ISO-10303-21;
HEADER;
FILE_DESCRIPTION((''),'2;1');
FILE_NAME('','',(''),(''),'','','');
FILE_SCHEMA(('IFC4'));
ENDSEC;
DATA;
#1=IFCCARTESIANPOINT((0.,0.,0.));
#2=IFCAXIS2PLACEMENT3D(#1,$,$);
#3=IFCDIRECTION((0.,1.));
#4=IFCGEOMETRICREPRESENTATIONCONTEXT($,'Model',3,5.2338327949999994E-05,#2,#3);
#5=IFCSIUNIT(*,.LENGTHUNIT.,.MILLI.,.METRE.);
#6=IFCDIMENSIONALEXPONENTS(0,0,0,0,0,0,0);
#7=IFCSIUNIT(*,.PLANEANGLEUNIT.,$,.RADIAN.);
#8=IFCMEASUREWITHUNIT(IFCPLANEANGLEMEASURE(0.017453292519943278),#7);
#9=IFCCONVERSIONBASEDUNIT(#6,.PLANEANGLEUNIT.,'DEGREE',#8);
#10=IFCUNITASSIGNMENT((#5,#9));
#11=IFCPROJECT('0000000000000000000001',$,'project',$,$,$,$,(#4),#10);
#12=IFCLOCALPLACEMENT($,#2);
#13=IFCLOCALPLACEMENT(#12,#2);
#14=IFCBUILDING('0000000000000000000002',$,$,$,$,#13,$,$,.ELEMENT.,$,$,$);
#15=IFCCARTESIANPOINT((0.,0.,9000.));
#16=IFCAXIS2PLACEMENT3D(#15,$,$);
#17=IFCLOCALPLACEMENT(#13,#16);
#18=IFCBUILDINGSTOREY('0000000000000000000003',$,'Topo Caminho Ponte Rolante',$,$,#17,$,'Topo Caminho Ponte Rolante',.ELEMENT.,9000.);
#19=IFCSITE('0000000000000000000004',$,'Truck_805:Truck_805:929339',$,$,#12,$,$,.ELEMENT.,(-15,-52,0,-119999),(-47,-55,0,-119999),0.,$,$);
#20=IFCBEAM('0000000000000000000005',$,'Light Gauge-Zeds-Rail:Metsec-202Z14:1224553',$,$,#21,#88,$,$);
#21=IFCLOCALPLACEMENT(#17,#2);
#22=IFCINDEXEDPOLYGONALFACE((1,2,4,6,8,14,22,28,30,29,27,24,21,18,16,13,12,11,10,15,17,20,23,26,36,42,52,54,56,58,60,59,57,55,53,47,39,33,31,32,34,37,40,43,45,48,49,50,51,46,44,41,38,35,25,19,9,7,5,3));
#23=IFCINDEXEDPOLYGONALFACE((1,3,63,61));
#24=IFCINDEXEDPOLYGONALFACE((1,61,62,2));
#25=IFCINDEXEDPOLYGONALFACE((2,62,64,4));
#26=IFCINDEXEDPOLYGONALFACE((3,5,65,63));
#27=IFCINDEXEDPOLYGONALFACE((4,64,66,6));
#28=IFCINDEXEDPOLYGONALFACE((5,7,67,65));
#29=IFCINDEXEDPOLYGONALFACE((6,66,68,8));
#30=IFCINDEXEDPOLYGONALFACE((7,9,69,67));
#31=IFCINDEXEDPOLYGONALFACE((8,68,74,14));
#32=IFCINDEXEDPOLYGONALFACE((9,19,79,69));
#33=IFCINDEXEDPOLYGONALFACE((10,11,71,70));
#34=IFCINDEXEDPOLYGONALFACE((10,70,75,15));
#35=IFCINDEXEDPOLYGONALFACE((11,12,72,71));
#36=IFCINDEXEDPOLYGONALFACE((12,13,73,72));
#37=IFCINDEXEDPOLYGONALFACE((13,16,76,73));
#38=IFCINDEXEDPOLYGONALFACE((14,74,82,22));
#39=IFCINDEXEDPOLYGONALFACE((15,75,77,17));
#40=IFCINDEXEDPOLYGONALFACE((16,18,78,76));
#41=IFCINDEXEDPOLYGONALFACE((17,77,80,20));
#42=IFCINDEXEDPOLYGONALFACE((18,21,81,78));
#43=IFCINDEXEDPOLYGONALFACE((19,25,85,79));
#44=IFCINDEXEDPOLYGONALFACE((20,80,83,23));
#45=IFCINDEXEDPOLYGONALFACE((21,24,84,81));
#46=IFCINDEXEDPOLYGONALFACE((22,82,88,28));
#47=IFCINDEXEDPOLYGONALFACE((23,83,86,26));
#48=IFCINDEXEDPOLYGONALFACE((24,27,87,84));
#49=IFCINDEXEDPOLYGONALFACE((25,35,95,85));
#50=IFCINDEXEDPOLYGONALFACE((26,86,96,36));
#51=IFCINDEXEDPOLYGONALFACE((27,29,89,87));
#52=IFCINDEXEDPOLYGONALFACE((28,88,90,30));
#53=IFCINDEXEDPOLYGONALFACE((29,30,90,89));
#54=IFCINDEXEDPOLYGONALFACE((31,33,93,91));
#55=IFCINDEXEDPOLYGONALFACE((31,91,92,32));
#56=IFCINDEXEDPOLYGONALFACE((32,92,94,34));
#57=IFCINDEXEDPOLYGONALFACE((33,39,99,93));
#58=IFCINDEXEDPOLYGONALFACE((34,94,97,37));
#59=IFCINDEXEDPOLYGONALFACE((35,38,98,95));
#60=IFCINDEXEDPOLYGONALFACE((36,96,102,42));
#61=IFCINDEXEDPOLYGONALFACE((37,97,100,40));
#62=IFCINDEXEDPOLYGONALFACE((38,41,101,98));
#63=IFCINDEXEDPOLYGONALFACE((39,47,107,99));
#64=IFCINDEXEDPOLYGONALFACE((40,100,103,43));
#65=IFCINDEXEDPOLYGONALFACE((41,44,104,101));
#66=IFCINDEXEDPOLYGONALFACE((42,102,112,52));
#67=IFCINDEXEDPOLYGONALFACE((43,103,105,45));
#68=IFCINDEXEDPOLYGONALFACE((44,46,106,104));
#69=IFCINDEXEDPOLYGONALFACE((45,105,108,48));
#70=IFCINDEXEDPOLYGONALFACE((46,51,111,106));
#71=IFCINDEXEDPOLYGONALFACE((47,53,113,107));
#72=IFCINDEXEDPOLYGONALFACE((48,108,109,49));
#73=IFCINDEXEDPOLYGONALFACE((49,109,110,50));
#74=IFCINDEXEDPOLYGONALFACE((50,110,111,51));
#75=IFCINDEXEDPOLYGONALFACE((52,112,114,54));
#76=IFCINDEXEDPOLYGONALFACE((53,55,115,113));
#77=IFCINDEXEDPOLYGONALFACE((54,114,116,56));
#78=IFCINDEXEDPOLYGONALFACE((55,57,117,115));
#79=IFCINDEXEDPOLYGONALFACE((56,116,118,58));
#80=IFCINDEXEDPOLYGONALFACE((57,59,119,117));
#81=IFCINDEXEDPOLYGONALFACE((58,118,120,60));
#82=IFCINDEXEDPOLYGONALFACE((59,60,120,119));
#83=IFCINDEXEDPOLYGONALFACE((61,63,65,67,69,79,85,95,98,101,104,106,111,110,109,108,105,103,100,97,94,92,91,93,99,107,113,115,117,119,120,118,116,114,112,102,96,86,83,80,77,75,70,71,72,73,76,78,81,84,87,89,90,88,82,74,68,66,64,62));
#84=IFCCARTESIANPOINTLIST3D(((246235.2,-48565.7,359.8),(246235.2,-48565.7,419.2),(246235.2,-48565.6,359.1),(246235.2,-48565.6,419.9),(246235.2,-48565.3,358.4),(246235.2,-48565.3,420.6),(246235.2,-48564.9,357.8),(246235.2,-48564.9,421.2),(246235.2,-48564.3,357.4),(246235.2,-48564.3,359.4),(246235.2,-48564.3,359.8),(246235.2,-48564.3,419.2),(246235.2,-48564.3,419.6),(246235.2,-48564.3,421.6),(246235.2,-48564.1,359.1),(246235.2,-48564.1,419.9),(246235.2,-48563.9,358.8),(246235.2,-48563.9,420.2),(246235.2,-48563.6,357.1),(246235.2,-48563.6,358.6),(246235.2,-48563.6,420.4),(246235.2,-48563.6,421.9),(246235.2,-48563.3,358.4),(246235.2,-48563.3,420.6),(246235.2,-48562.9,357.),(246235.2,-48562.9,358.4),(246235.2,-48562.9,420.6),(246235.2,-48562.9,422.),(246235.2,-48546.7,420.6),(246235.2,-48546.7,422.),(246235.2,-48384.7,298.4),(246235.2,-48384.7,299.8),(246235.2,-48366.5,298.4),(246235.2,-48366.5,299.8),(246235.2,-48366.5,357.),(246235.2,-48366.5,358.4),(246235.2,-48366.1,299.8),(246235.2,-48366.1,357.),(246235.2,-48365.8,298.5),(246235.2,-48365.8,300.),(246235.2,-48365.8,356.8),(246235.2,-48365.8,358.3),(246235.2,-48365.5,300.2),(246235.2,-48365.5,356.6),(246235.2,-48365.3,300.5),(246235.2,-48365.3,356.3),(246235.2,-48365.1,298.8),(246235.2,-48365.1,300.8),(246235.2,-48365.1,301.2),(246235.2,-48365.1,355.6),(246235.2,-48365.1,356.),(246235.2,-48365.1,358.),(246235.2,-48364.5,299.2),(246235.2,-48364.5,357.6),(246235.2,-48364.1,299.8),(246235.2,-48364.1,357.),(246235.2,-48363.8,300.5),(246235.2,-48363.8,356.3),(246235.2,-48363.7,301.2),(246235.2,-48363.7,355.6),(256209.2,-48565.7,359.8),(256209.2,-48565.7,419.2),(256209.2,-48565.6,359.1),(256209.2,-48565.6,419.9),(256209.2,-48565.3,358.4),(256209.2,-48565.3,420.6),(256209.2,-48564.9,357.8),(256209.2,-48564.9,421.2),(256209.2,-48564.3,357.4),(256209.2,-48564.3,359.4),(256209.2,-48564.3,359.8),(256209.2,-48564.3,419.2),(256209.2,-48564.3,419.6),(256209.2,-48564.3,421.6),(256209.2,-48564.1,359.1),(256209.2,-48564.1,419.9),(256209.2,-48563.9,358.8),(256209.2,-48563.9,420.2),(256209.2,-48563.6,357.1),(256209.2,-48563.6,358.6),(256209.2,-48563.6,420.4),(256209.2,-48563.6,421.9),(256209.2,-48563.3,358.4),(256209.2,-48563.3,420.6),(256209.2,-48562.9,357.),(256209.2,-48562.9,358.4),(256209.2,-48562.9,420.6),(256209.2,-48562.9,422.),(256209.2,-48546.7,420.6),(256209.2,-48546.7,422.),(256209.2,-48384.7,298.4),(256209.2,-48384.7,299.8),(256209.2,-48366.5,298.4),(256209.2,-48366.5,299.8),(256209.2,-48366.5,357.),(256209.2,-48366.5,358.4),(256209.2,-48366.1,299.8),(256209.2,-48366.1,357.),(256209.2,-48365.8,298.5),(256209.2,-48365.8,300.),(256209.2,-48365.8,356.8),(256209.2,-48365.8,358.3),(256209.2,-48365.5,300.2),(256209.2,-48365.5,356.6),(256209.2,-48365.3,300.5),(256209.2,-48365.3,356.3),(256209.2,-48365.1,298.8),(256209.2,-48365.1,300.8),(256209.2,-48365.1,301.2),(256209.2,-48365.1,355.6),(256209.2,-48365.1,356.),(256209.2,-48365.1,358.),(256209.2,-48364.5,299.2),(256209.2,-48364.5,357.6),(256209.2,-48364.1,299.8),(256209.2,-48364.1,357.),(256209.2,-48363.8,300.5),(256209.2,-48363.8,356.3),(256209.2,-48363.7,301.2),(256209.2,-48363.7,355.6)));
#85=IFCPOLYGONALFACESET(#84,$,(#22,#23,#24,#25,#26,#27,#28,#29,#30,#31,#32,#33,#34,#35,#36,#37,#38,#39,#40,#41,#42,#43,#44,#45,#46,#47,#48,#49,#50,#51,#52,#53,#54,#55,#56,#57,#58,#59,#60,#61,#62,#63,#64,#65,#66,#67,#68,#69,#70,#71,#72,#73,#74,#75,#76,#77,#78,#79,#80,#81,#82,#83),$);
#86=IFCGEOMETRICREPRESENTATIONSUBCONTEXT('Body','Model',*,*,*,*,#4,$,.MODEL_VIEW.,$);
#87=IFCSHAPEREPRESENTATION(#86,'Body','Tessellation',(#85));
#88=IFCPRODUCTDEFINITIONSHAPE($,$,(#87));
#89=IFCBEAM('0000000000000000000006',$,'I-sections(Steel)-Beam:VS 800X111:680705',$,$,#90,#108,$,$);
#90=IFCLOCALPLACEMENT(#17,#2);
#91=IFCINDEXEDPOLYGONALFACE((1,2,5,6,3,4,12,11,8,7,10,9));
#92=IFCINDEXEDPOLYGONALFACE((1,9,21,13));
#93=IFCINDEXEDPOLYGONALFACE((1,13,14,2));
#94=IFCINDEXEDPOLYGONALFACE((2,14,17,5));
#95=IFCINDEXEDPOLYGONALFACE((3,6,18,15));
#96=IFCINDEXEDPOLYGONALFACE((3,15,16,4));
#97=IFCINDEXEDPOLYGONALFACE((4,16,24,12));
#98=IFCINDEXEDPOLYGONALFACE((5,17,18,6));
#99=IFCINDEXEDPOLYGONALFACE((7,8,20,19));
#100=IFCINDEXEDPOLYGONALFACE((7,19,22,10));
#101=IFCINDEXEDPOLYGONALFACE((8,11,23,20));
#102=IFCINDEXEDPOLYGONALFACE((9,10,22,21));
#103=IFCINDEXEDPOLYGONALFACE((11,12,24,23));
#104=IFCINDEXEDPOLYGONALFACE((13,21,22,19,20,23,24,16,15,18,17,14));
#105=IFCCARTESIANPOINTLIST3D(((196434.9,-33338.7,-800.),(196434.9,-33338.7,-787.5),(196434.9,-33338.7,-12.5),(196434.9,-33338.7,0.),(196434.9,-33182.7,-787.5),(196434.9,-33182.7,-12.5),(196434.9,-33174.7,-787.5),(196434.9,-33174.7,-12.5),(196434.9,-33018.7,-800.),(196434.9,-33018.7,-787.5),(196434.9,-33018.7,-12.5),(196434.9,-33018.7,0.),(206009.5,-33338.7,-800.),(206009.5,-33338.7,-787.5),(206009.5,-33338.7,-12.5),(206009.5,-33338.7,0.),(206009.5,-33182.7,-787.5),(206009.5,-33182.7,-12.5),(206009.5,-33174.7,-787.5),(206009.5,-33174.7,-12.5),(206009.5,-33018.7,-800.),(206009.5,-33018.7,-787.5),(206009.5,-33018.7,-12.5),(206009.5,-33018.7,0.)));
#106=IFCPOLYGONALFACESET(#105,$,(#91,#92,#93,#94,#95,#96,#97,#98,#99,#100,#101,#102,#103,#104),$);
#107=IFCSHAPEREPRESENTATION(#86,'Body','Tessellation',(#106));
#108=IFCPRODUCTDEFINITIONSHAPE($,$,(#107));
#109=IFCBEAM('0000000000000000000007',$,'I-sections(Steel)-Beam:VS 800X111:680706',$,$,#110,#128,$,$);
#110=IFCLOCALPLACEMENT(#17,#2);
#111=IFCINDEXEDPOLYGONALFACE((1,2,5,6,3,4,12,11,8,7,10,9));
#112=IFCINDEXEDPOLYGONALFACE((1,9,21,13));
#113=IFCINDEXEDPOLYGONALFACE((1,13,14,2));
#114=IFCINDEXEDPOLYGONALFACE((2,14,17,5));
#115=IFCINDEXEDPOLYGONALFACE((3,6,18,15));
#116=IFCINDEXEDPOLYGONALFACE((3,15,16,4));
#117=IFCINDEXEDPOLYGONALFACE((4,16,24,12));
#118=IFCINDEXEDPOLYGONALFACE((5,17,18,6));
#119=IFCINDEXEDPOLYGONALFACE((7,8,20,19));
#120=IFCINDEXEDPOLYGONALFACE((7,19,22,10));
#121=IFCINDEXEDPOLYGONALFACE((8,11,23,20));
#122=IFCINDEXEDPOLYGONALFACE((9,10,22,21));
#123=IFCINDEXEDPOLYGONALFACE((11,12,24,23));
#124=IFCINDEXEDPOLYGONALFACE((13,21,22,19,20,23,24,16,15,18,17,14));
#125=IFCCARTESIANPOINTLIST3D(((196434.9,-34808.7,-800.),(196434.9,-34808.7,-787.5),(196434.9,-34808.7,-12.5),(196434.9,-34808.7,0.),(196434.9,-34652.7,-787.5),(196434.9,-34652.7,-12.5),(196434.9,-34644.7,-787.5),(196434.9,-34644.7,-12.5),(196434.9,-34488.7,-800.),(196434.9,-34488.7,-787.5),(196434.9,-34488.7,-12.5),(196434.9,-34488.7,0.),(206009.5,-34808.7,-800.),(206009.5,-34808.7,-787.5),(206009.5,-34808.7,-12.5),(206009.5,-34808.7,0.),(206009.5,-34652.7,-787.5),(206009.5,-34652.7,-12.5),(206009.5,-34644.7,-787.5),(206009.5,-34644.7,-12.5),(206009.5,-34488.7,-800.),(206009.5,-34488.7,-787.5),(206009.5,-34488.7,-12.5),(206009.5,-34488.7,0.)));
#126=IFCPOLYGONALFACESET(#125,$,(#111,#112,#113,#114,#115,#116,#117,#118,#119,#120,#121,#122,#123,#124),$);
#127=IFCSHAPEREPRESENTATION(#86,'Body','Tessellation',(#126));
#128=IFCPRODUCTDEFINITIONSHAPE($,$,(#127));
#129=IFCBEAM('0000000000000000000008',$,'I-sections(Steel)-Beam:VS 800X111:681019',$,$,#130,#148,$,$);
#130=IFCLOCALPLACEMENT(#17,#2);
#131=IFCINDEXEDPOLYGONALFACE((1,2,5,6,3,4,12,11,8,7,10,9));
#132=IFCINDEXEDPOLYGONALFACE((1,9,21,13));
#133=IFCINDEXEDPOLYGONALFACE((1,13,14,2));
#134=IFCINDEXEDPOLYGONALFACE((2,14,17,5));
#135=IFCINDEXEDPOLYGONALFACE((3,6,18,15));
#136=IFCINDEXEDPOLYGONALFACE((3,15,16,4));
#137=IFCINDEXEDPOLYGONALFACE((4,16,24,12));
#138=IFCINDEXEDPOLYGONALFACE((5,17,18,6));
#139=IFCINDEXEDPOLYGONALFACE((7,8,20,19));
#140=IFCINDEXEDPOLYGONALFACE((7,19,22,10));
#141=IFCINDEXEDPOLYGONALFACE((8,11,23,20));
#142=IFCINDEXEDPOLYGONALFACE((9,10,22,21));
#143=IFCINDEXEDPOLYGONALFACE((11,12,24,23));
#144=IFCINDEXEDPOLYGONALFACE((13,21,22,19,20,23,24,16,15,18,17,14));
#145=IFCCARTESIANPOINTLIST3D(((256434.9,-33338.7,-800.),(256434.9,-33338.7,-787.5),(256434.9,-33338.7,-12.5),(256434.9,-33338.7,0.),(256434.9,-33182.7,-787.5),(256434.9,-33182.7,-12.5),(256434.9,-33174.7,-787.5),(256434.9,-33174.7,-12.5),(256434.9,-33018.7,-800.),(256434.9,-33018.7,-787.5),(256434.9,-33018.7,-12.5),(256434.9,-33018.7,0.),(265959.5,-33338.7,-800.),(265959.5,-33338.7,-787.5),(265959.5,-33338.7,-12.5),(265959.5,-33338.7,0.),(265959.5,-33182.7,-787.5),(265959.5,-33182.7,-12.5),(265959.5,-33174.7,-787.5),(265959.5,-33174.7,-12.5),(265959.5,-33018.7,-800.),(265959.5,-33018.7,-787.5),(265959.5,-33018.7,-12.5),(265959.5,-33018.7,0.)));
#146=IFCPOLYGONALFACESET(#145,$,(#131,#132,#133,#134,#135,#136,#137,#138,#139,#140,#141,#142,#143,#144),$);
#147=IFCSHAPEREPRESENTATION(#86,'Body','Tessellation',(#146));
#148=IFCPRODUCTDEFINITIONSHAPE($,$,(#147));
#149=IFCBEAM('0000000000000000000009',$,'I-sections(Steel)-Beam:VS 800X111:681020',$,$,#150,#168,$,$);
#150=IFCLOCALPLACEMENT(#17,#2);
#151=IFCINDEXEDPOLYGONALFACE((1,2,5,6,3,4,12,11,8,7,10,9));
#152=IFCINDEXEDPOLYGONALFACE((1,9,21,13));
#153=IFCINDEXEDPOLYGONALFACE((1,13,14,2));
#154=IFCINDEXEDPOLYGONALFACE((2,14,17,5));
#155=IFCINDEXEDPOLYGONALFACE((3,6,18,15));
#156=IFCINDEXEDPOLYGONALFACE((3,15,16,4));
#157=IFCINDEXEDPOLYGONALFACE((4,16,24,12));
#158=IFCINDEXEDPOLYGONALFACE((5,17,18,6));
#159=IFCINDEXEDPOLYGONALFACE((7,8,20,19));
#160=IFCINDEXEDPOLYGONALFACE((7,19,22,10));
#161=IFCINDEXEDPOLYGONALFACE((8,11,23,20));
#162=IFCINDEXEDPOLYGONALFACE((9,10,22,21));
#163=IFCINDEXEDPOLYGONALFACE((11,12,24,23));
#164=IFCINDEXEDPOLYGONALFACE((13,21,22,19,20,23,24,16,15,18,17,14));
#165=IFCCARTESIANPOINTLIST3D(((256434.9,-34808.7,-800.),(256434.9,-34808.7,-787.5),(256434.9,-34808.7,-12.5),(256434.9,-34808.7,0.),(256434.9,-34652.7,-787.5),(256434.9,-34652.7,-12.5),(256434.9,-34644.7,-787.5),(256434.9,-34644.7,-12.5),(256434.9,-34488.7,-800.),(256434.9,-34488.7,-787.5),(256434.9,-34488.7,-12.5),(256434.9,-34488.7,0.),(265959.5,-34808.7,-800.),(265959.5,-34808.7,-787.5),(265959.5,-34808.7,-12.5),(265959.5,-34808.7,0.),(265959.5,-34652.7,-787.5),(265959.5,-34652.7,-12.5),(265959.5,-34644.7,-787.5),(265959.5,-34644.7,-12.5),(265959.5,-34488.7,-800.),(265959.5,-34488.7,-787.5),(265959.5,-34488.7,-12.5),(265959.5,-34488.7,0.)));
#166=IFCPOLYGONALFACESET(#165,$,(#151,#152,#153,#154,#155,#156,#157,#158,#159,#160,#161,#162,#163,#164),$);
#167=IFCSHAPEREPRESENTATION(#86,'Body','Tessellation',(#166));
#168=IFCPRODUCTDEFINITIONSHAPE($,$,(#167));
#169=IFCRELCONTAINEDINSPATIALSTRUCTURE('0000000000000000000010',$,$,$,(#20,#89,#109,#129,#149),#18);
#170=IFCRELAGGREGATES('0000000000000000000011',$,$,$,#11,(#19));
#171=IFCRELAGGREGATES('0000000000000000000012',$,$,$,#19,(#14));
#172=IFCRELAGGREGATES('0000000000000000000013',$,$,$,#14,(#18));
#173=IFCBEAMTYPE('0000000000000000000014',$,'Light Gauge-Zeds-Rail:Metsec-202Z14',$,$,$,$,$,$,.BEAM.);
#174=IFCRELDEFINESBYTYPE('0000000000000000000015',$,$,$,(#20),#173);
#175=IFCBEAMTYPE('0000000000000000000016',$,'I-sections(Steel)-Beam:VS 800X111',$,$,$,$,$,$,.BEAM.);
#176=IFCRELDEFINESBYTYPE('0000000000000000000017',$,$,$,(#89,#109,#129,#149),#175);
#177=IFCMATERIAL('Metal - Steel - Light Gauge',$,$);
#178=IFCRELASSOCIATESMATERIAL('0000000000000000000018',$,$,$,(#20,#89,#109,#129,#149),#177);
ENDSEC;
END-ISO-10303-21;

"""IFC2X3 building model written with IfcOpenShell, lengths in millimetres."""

from ifc_helpers import new_model, entity, si_unit, converted_unit, direction, frame, frame_2d, origin, place, context, subcontext, project, spatial, polyline, circle_curve, parameter, trimmed, segment, composite_curve, i_section, outline, extrude, material, type_object, element, save


model = new_model("IFC2X3")

# Units and contexts
model_context = context("Model", 3, precision=5.2338327949999994e-05, world=origin(), true_north=direction((0.0, 1.0)))
body_context = subcontext(model_context, "Body", "Model", "MODEL_VIEW")
ifc_project = project(units=[si_unit("LENGTHUNIT", "METRE", prefix="MILLI"), converted_unit("PLANEANGLEUNIT", "DEGREE", entity("IfcPlaneAngleMeasure", 0.017453292519943278), si_unit("PLANEANGLEUNIT", "RADIAN"), dimensions=[0, 0, 0, 0, 0, 0, 0])], contexts=[model_context])

# Site, building, storey
site_placement = place(None, origin())
site = spatial("IfcSite", under=ifc_project, at=site_placement, Name="Truck_805:Truck_805:929339", CompositionType="ELEMENT", RefLatitude=(-15, -52, 0, -119999), RefLongitude=(-47, -55, 0, -119999), RefElevation=0.0)
building_placement = place(site_placement, origin())
building = spatial("IfcBuilding", under=site, at=building_placement, CompositionType="ELEMENT")
storey_placement = place(building_placement, frame((0.0, 0.0, 9000.0)))
storey = spatial("IfcBuildingStorey", under=building, at=storey_placement, Name="Topo Caminho Ponte Rolante", LongName="Topo Caminho Ponte Rolante", CompositionType="ELEMENT", Elevation=9000.0)

# Beams
ifc_material = material(Name="Metal - Steel - Light Gauge")
beam_type_1 = type_object("IfcBeamType", Name="Light Gauge-Zeds-Rail:Metsec-202Z14", PredefinedType="BEAM")
beam_1_placement = place(storey_placement, frame((246222.2, -48465.6, 422.0)))
element("IfcBeam", 1, at=beam_1_placement, inside=storey, type_object=beam_type_1, material=ifc_material, Name="Light Gauge-Zeds-Rail:Metsec-202Z14:1224553", context=body_context, shape_type="SweptSolid", body=[
    extrude(outline(composite_curve([segment(polyline([(-60.0, -100.8), (-0.6, -100.8)]), True, "CONTINUOUS"), segment(trimmed(circle_curve(frame_2d((-0.6, -98.0), x_axis=(0.0, -1.0)), 2.8), [parameter(0.0)], [parameter(90.0)], True, "PARAMETER"), True, "CONTINUOUS"), segment(polyline([(2.2, -98.0), (2.2, 98.4)]), True, "CONTINUOUS"), segment(trimmed(circle_curve(frame_2d((3.6, 98.4), x_axis=(-1.0, 0.0)), 1.4), [parameter(270.0)], [parameter(0.0)], True, "PARAMETER"), False, "CONTINUOUS"), segment(polyline([(3.6, 99.8), (58.0, 99.8)]), True, "CONTINUOUS"), segment(trimmed(circle_curve(frame_2d((58.0, 98.4), x_axis=(0.0, 1.0)), 1.4), [parameter(270.0)], [parameter(0.0)], True, "PARAMETER"), False, "CONTINUOUS"), segment(polyline([(59.4, 98.4), (59.4, 80.2)]), True, "CONTINUOUS"), segment(polyline([(59.4, 80.2), (60.8, 80.2)]), True, "CONTINUOUS"), segment(polyline([(60.8, 80.2), (60.8, 98.4)]), True, "CONTINUOUS"), segment(trimmed(circle_curve(frame_2d((58.0, 98.4), x_axis=(1.0, 0.0)), 2.8), [parameter(0.0)], [parameter(90.0)], True, "PARAMETER"), True, "CONTINUOUS"), segment(polyline([(58.0, 101.2), (3.6, 101.2)]), True, "CONTINUOUS"), segment(trimmed(circle_curve(frame_2d((3.6, 98.4), x_axis=(0.0, 1.0)), 2.8), [parameter(0.0)], [parameter(90.0)], True, "PARAMETER"), True, "CONTINUOUS"), segment(polyline([(0.8, 98.4), (0.8, -98.0)]), True, "CONTINUOUS"), segment(trimmed(circle_curve(frame_2d((-0.6, -98.0), x_axis=(1.0, 0.0)), 1.4), [parameter(270.0)], [parameter(0.0)], True, "PARAMETER"), False, "CONTINUOUS"), segment(polyline([(-0.6, -99.4), (-60.0, -99.4)]), True, "CONTINUOUS"), segment(trimmed(circle_curve(frame_2d((-60.0, -98.0), x_axis=(0.0, -1.0)), 1.4), [parameter(270.0)], [parameter(0.0)], True, "PARAMETER"), False, "CONTINUOUS"), segment(polyline([(-61.4, -98.0), (-61.4, -81.8)]), True, "CONTINUOUS"), segment(polyline([(-61.4, -81.8), (-62.8, -81.8)]), True, "CONTINUOUS"), segment(polyline([(-62.8, -81.8), (-62.8, -98.0)]), True, "CONTINUOUS"), segment(trimmed(circle_curve(frame_2d((-60.0, -98.0), x_axis=(-1.0, 0.0)), 2.8), [parameter(0.0)], [parameter(90.0)], True, "PARAMETER"), True, "CONTINUOUS")], self_intersect=False)), frame((13.0, 0.7, -62.8), z_axis=(1.0, 0.0, 0.0), x_axis=(0.0, 0.0, -1.0)), (0.0, 0.0, 1.0), 9974.0),
])
beam_type_2 = type_object("IfcBeamType", Name="I-sections(Steel)-Beam:VS 800X111", PredefinedType="BEAM")
beam_2_placement = place(storey_placement, frame((196222.2, -33178.7, 0.0)))
element("IfcBeam", 2, at=beam_2_placement, inside=storey, type_object=beam_type_2, material=ifc_material, Name="I-sections(Steel)-Beam:VS 800X111:680705", context=body_context, shape_type="SweptSolid", body=[
    extrude(i_section(OverallWidth=320.0, OverallDepth=800.0, WebThickness=8.0, FlangeThickness=12.5, at=frame_2d((0.0, 0.0), x_axis=(0.0, 1.0))), frame((212.7, 0.0, -400.0), z_axis=(1.0, 0.0, 0.0), x_axis=(0.0, 0.0, -1.0)), (0.0, 0.0, 1.0), 9574.6),
])
beam_3_placement = place(storey_placement, frame((196222.2, -34648.7, 0.0)))
element("IfcBeam", 3, at=beam_3_placement, inside=storey, type_object=beam_type_2, material=ifc_material, Name="I-sections(Steel)-Beam:VS 800X111:680706", context=body_context, shape_type="SweptSolid", body=[
    extrude(outline(polyline([(387.5, -160.0), (400.0, -160.0), (400.0, 160.0), (387.5, 160.0), (387.5, 4.0), (-387.5, 4.0), (-387.5, 160.0), (-400.0, 160.0), (-400.0, -160.0), (-387.5, -160.0), (-387.5, -4.0), (387.5, -4.0), (387.5, -160.0)])), frame((212.7, 0.0, -400.0), z_axis=(1.0, 0.0, 0.0), x_axis=(0.0, 0.0, -1.0)), (0.0, 0.0, 1.0), 9574.6),
])
beam_4_placement = place(storey_placement, frame((256222.2, -33178.7, 0.0)))
element("IfcBeam", 4, at=beam_4_placement, inside=storey, type_object=beam_type_2, material=ifc_material, Name="I-sections(Steel)-Beam:VS 800X111:681019", context=body_context, shape_type="SweptSolid", body=[
    extrude(i_section(OverallWidth=320.0, OverallDepth=800.0, WebThickness=8.0, FlangeThickness=12.5, at=frame_2d((0.0, 0.0), x_axis=(0.0, 1.0))), frame((212.7, 0.0, -400.0), z_axis=(1.0, 0.0, 0.0), x_axis=(0.0, 0.0, -1.0)), (0.0, 0.0, 1.0), 9524.6),
])
beam_5_placement = place(storey_placement, frame((256222.2, -34648.7, 0.0)))
element("IfcBeam", 5, at=beam_5_placement, inside=storey, type_object=beam_type_2, material=ifc_material, Name="I-sections(Steel)-Beam:VS 800X111:681020", context=body_context, shape_type="SweptSolid", body=[
    extrude(outline(polyline([(387.5, -160.0), (400.0, -160.0), (400.0, 160.0), (387.5, 160.0), (387.5, 4.0), (-387.5, 4.0), (-387.5, 160.0), (-400.0, 160.0), (-400.0, -160.0), (-387.5, -160.0), (-387.5, -4.0), (387.5, -4.0), (387.5, -160.0)])), frame((212.7, 0.0, -400.0), z_axis=(1.0, 0.0, 0.0), x_axis=(0.0, 0.0, -1.0)), (0.0, 0.0, 1.0), 9524.6),
])

save(model, "model.ifc")
